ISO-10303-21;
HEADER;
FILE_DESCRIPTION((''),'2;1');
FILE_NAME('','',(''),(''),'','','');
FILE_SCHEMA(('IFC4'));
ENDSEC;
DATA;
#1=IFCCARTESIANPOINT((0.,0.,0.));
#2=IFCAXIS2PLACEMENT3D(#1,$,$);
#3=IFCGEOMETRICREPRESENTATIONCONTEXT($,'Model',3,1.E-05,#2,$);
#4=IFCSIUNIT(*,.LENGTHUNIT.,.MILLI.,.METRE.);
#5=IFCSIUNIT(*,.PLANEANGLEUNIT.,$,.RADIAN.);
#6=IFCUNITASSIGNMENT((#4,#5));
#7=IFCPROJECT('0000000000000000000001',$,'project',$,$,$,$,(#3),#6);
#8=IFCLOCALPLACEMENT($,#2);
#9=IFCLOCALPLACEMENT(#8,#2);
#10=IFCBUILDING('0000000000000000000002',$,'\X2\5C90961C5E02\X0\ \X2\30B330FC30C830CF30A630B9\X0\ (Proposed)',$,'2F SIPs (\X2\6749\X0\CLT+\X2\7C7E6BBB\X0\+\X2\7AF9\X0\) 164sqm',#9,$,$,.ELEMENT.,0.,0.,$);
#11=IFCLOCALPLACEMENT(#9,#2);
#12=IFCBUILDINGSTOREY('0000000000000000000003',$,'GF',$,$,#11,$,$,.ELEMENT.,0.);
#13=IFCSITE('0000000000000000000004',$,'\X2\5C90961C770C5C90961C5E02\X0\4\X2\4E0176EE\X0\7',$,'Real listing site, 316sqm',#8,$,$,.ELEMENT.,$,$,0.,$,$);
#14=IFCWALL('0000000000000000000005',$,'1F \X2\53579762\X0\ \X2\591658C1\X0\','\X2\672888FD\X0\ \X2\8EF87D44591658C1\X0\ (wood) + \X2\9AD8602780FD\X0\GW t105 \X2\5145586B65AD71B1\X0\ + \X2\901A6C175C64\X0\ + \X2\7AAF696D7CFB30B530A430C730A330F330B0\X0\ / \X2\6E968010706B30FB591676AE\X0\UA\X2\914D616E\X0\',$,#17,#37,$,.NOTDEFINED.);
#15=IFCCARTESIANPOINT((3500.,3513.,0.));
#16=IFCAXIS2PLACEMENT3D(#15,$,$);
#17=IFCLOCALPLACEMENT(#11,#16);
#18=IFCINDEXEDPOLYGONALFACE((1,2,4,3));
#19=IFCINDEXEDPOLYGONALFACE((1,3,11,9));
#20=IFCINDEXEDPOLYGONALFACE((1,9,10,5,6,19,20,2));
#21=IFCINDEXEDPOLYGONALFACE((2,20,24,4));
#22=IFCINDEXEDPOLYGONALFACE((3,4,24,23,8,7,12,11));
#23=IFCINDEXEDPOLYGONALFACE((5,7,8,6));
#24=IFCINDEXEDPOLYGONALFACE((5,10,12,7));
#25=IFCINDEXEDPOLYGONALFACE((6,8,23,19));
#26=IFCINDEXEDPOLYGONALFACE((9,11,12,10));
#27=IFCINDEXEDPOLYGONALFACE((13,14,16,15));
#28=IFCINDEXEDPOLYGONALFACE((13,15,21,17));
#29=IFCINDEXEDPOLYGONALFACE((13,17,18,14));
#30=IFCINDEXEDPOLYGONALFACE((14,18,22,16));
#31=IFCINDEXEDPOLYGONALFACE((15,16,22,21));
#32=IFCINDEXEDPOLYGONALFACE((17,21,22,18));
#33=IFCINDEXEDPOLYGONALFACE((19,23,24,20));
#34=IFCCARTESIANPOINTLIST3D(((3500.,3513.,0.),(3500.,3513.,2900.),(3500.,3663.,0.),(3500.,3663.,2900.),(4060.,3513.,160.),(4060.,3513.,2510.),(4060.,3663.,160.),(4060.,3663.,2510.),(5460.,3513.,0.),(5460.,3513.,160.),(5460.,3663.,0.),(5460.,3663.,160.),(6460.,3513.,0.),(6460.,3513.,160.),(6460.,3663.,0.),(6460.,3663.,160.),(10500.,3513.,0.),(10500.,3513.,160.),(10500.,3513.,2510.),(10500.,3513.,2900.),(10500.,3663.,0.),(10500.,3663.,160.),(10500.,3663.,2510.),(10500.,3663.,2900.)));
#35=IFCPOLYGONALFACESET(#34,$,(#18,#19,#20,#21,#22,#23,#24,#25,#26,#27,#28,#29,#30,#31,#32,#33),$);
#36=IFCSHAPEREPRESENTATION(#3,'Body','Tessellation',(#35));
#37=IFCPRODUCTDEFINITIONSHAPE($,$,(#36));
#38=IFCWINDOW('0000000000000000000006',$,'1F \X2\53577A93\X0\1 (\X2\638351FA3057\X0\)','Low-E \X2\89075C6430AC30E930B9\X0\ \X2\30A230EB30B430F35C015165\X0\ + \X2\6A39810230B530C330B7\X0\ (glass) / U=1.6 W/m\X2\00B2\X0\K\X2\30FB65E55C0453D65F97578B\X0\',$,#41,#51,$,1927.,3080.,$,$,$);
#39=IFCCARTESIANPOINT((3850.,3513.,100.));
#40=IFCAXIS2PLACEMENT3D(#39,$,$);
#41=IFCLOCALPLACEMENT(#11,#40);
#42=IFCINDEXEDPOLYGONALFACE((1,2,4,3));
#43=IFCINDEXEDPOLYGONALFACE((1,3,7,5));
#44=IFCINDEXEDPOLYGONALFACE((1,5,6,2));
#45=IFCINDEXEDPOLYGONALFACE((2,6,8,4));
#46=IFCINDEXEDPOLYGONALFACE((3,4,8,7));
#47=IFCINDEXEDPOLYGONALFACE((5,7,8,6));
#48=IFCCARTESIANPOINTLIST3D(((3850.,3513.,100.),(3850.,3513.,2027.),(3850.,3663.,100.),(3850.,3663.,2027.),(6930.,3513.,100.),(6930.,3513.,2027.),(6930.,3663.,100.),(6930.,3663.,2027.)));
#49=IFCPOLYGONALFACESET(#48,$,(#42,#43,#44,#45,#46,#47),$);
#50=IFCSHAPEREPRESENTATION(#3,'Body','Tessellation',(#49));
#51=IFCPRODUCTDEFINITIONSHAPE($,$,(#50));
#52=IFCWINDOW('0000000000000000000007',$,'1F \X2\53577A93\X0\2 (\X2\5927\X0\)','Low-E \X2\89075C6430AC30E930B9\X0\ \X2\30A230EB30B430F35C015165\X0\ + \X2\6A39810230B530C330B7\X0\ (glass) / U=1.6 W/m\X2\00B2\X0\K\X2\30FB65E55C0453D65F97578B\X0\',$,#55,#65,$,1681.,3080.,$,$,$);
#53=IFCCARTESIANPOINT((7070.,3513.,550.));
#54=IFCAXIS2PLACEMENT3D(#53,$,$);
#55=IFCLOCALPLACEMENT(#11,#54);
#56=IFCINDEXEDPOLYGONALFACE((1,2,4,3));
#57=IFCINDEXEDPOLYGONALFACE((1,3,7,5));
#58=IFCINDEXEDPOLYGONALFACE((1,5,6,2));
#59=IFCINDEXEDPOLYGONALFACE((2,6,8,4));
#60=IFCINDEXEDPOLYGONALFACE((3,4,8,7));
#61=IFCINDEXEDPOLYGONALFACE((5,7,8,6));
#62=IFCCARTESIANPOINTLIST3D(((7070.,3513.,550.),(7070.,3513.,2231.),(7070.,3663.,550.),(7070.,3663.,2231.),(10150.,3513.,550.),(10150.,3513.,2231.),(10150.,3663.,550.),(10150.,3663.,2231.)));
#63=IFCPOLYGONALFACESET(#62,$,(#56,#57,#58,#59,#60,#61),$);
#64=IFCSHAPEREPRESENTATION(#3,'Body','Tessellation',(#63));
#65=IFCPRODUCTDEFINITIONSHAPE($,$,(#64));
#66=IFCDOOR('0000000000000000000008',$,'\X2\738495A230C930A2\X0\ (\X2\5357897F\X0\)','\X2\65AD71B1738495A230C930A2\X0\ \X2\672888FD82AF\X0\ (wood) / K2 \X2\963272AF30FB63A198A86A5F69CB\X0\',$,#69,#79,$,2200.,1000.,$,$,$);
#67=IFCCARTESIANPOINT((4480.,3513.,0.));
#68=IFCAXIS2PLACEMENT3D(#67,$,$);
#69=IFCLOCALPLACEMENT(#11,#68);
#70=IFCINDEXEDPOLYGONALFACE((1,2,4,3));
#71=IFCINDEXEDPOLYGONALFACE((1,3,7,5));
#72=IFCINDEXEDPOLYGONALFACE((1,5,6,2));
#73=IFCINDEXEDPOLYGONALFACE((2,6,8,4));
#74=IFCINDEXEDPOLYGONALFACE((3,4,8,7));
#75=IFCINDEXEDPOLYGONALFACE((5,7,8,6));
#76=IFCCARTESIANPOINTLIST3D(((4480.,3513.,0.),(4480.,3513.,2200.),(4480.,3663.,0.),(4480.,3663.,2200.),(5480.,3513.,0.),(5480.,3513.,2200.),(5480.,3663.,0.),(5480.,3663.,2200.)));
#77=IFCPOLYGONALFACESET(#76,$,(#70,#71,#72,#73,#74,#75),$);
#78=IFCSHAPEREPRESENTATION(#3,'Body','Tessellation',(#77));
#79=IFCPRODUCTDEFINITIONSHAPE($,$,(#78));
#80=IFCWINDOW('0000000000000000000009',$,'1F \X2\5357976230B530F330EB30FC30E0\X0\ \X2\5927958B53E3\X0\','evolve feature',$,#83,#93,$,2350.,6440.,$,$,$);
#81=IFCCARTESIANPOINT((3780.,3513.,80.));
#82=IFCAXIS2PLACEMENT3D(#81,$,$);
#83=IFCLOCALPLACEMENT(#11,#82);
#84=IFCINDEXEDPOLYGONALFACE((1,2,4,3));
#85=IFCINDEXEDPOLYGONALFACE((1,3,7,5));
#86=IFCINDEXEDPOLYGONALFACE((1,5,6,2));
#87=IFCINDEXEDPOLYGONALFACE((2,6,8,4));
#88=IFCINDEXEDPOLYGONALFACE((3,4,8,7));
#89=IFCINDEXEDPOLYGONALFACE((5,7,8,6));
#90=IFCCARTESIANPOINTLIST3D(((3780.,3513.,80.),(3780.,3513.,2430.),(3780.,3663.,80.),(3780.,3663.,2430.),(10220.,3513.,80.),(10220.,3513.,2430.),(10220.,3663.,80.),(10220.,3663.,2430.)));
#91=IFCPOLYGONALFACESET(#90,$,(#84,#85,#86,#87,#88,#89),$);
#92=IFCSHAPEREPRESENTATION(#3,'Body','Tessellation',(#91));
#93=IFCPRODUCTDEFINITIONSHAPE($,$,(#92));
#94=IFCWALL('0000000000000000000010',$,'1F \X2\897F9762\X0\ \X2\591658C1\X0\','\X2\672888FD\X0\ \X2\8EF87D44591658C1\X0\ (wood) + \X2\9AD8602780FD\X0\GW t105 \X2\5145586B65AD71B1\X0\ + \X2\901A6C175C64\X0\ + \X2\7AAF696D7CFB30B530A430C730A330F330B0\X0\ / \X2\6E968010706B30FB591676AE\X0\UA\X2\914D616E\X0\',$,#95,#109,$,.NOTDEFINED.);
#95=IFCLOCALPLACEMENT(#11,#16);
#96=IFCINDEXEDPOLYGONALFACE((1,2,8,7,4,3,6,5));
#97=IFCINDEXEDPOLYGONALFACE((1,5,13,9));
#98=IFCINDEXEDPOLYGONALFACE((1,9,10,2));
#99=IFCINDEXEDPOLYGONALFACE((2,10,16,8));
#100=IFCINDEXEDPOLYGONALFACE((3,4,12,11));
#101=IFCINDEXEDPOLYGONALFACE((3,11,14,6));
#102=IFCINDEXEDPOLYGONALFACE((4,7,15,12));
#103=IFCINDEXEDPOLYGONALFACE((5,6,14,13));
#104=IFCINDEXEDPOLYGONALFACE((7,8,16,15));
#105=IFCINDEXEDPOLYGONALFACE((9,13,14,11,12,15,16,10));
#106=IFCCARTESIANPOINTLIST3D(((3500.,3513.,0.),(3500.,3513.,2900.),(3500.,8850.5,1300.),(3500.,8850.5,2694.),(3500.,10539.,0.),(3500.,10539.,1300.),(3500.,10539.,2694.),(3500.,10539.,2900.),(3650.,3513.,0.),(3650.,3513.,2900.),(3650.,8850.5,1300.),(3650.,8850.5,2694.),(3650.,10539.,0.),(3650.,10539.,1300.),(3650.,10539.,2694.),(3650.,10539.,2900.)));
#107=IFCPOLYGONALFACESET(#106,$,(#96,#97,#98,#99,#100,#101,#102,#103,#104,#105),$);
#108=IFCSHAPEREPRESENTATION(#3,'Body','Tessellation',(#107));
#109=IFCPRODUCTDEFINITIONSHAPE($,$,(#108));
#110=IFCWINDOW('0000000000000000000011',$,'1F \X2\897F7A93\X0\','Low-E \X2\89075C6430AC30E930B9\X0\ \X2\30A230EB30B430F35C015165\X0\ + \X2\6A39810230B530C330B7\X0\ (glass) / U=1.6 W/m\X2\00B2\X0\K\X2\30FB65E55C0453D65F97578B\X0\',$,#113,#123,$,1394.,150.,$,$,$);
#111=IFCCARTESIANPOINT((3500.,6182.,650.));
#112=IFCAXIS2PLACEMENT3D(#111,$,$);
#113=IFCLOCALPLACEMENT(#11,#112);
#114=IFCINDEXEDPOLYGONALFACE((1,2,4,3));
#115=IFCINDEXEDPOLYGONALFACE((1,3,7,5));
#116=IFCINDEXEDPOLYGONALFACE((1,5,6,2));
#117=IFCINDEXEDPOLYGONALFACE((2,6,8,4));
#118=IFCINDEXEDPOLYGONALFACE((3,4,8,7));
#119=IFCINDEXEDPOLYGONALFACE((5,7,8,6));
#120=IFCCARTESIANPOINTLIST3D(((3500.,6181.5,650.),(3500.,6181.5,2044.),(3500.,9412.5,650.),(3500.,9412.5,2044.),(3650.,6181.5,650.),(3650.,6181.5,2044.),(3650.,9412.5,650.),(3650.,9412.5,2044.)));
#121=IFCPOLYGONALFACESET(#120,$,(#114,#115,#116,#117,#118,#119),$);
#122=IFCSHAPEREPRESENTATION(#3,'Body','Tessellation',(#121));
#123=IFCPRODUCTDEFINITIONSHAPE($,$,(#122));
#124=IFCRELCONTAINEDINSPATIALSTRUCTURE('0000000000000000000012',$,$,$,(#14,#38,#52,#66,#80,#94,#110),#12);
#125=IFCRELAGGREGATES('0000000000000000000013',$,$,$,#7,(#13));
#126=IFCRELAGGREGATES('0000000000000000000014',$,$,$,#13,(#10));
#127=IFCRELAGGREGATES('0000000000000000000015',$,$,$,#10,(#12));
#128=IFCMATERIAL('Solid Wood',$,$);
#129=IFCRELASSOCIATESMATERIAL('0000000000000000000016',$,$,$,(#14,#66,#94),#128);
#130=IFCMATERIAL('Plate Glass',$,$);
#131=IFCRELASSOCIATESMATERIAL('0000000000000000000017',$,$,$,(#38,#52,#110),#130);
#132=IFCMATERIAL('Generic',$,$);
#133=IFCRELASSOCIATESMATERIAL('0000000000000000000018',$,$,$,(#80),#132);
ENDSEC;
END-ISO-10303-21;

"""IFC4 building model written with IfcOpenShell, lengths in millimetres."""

from ifc_helpers import new_model, si_unit, frame, frame_2d, origin, place, context, project, spatial, rectangle, extrude, material, element, fill, save


model = new_model("IFC4")

# Units and contexts
model_context = context("Model", 3, precision=1e-05, world=origin())
ifc_project = project(units=[si_unit("LENGTHUNIT", "METRE", prefix="MILLI"), si_unit("PLANEANGLEUNIT", "RADIAN")], contexts=[model_context])

# Site, building, storey
site_placement = place(None, origin())
site = spatial("IfcSite", under=ifc_project, at=site_placement, Name="岐阜県岐阜市4丁目7", ObjectType="Real listing site, 316sqm", CompositionType="ELEMENT", RefElevation=0.0)
building_placement = place(site_placement, origin())
building = spatial("IfcBuilding", under=site, at=building_placement, Name="岐阜市 コートハウス (Proposed)", ObjectType="2F SIPs (杉CLT+籾殻+竹) 164sqm", CompositionType="ELEMENT", ElevationOfRefHeight=0.0, ElevationOfTerrain=0.0)
storey_placement = place(building_placement, origin())
storey = spatial("IfcBuildingStorey", under=building, at=storey_placement, Name="GF", CompositionType="ELEMENT", Elevation=0.0)

# Shared definitions
ifc_material_1 = material(Name="Solid Wood")
ifc_material_2 = material(Name="Generic")

# Wall, openings, windows, door
wall_1_placement = place(storey_placement, frame((3500.0, 3513.0, 0.0)))
wall_1 = element("IfcWall", 1, at=wall_1_placement, inside=storey, material=ifc_material_1, Name="1F 南面 外壁", Description="木製 軸組外壁 (wood) + 高性能GW t105 充填断熱 + 通気層 + 窯業系サイディング / 準耐火・外皮UA配慮", PredefinedType="NOTDEFINED", context=model_context, shape_type="SweptSolid", body=[
    extrude(rectangle(XDim=7000.0, YDim=150.0, at=frame_2d((3500.0, 75.0))), frame((3500.0, 3513.0, 0.0)), (0.0, 0.0, 1.0), 2900.0),
])
opening_1_placement = place(storey_placement, frame((3850.0, 3513.0, 100.0)))
opening_1 = element("IfcOpeningElement", 2, at=opening_1_placement, cuts=wall_1, PredefinedType="NOTDEFINED", context=model_context, shape_type="SweptSolid", body=[
    extrude(rectangle(XDim=3080.0, YDim=150.0, at=frame_2d((1540.0, 75.0))), frame((3850.0, 3513.0, 100.0)), (0.0, 0.0, 1.0), 1927.0),
])
opening_2_placement = place(storey_placement, frame((7070.0, 3513.0, 550.0)))
opening_2 = element("IfcOpeningElement", 3, at=opening_2_placement, cuts=wall_1, PredefinedType="NOTDEFINED", context=model_context, shape_type="SweptSolid", body=[
    extrude(rectangle(XDim=3080.0, YDim=150.0, at=frame_2d((1540.0, 75.0))), frame((7070.0, 3513.0, 550.0)), (0.0, 0.0, 1.0), 1681.0),
])
opening_3_placement = place(storey_placement, frame((4480.0, 3513.0, 0.0)))
opening_3 = element("IfcOpeningElement", 4, at=opening_3_placement, cuts=wall_1, PredefinedType="NOTDEFINED", context=model_context, shape_type="SweptSolid", body=[
    extrude(rectangle(XDim=1000.0, YDim=150.0, at=frame_2d((500.0, 75.0))), frame((4480.0, 3513.0, 0.0)), (0.0, 0.0, 1.0), 2200.0),
])
opening_4_placement = place(storey_placement, frame((3780.0, 3513.0, 80.0)))
opening_4 = element("IfcOpeningElement", 5, at=opening_4_placement, cuts=wall_1, PredefinedType="NOTDEFINED", context=model_context, shape_type="SweptSolid", body=[
    extrude(rectangle(XDim=6440.0, YDim=150.0, at=frame_2d((3220.0, 75.0))), frame((3780.0, 3513.0, 80.0)), (0.0, 0.0, 1.0), 2350.0),
])
ifc_material_3 = material(Name="Plate Glass")
window_1_placement = place(storey_placement, frame((3850.0, 3513.0, 100.0)))
window_1 = element("IfcWindow", 6, at=window_1_placement, inside=storey, material=ifc_material_3, Name="1F 南窓1 (掃出し)", Description="Low-E 複層ガラス アルゴン封入 + 樹脂サッシ (glass) / U=1.6 W/m²K・日射取得型", OverallHeight=1927.0, OverallWidth=3080.0, context=model_context, shape_type="SweptSolid", body=[
    extrude(rectangle(XDim=3080.0, YDim=150.0, at=frame_2d((1540.0, 75.0))), frame((3850.0, 3513.0, 100.0)), (0.0, 0.0, 1.0), 1927.0),
])
fill(opening_1, window_1)
window_2_placement = place(storey_placement, frame((7070.0, 3513.0, 550.0)))
window_2 = element("IfcWindow", 7, at=window_2_placement, inside=storey, material=ifc_material_3, Name="1F 南窓2 (大)", Description="Low-E 複層ガラス アルゴン封入 + 樹脂サッシ (glass) / U=1.6 W/m²K・日射取得型", OverallHeight=1681.0, OverallWidth=3080.0, context=model_context, shape_type="SweptSolid", body=[
    extrude(rectangle(XDim=3080.0, YDim=150.0, at=frame_2d((1540.0, 75.0))), frame((7070.0, 3513.0, 550.0)), (0.0, 0.0, 1.0), 1681.0),
])
fill(opening_2, window_2)
door_placement = place(storey_placement, frame((4480.0, 3513.0, 0.0)))
door = element("IfcDoor", 8, at=door_placement, inside=storey, material=ifc_material_1, Name="玄関ドア (南西)", Description="断熱玄関ドア 木製芯 (wood) / K2 防犯・採風機構", OverallHeight=2200.0, OverallWidth=1000.0, context=model_context, shape_type="SweptSolid", body=[
    extrude(rectangle(XDim=1000.0, YDim=150.0, at=frame_2d((500.0, 75.0))), frame((4480.0, 3513.0, 0.0)), (0.0, 0.0, 1.0), 2200.0),
])
fill(opening_3, door)
window_3_placement = place(storey_placement, frame((3780.0, 3513.0, 80.0)))
window_3 = element("IfcWindow", 9, at=window_3_placement, inside=storey, material=ifc_material_2, Name="1F 南面サンルーム 大開口", Description="evolve feature", OverallHeight=2350.0, OverallWidth=6440.0, context=model_context, shape_type="SweptSolid", body=[
    extrude(rectangle(XDim=6440.0, YDim=150.0, at=frame_2d((3220.0, 75.0))), frame((3780.0, 3513.0, 80.0)), (0.0, 0.0, 1.0), 2350.0),
])
fill(opening_4, window_3)

# Wall, opening, window
wall_2_placement = place(storey_placement, frame((3500.0, 3513.0, 0.0)))
wall_2 = element("IfcWall", 10, at=wall_2_placement, inside=storey, material=ifc_material_1, Name="1F 西面 外壁", Description="木製 軸組外壁 (wood) + 高性能GW t105 充填断熱 + 通気層 + 窯業系サイディング / 準耐火・外皮UA配慮", PredefinedType="NOTDEFINED", context=model_context, shape_type="SweptSolid", body=[
    extrude(rectangle(XDim=150.0, YDim=7026.0, at=frame_2d((75.0, 3513.0))), frame((3500.0, 3513.0, 0.0)), (0.0, 0.0, 1.0), 2900.0),
])
opening_5_placement = place(storey_placement, frame((3500.0, 6182.0, 650.0)))
opening_5 = element("IfcOpeningElement", 11, at=opening_5_placement, cuts=wall_2, PredefinedType="NOTDEFINED", context=model_context, shape_type="SweptSolid", body=[
    extrude(rectangle(XDim=150.0, YDim=3231.0, at=frame_2d((75.0, 1615.0))), frame((3500.0, 6182.0, 650.0)), (0.0, 0.0, 1.0), 1394.0),
])
window_4_placement = place(storey_placement, frame((3500.0, 6182.0, 650.0)))
window_4 = element("IfcWindow", 12, at=window_4_placement, inside=storey, material=ifc_material_3, Name="1F 西窓", Description="Low-E 複層ガラス アルゴン封入 + 樹脂サッシ (glass) / U=1.6 W/m²K・日射取得型", OverallHeight=1394.0, OverallWidth=150.0, context=model_context, shape_type="SweptSolid", body=[
    extrude(rectangle(XDim=150.0, YDim=3231.0, at=frame_2d((75.0, 1615.0))), frame((3500.0, 6182.0, 650.0)), (0.0, 0.0, 1.0), 1394.0),
])
fill(opening_5, window_4)

save(model, "model.ifc")
